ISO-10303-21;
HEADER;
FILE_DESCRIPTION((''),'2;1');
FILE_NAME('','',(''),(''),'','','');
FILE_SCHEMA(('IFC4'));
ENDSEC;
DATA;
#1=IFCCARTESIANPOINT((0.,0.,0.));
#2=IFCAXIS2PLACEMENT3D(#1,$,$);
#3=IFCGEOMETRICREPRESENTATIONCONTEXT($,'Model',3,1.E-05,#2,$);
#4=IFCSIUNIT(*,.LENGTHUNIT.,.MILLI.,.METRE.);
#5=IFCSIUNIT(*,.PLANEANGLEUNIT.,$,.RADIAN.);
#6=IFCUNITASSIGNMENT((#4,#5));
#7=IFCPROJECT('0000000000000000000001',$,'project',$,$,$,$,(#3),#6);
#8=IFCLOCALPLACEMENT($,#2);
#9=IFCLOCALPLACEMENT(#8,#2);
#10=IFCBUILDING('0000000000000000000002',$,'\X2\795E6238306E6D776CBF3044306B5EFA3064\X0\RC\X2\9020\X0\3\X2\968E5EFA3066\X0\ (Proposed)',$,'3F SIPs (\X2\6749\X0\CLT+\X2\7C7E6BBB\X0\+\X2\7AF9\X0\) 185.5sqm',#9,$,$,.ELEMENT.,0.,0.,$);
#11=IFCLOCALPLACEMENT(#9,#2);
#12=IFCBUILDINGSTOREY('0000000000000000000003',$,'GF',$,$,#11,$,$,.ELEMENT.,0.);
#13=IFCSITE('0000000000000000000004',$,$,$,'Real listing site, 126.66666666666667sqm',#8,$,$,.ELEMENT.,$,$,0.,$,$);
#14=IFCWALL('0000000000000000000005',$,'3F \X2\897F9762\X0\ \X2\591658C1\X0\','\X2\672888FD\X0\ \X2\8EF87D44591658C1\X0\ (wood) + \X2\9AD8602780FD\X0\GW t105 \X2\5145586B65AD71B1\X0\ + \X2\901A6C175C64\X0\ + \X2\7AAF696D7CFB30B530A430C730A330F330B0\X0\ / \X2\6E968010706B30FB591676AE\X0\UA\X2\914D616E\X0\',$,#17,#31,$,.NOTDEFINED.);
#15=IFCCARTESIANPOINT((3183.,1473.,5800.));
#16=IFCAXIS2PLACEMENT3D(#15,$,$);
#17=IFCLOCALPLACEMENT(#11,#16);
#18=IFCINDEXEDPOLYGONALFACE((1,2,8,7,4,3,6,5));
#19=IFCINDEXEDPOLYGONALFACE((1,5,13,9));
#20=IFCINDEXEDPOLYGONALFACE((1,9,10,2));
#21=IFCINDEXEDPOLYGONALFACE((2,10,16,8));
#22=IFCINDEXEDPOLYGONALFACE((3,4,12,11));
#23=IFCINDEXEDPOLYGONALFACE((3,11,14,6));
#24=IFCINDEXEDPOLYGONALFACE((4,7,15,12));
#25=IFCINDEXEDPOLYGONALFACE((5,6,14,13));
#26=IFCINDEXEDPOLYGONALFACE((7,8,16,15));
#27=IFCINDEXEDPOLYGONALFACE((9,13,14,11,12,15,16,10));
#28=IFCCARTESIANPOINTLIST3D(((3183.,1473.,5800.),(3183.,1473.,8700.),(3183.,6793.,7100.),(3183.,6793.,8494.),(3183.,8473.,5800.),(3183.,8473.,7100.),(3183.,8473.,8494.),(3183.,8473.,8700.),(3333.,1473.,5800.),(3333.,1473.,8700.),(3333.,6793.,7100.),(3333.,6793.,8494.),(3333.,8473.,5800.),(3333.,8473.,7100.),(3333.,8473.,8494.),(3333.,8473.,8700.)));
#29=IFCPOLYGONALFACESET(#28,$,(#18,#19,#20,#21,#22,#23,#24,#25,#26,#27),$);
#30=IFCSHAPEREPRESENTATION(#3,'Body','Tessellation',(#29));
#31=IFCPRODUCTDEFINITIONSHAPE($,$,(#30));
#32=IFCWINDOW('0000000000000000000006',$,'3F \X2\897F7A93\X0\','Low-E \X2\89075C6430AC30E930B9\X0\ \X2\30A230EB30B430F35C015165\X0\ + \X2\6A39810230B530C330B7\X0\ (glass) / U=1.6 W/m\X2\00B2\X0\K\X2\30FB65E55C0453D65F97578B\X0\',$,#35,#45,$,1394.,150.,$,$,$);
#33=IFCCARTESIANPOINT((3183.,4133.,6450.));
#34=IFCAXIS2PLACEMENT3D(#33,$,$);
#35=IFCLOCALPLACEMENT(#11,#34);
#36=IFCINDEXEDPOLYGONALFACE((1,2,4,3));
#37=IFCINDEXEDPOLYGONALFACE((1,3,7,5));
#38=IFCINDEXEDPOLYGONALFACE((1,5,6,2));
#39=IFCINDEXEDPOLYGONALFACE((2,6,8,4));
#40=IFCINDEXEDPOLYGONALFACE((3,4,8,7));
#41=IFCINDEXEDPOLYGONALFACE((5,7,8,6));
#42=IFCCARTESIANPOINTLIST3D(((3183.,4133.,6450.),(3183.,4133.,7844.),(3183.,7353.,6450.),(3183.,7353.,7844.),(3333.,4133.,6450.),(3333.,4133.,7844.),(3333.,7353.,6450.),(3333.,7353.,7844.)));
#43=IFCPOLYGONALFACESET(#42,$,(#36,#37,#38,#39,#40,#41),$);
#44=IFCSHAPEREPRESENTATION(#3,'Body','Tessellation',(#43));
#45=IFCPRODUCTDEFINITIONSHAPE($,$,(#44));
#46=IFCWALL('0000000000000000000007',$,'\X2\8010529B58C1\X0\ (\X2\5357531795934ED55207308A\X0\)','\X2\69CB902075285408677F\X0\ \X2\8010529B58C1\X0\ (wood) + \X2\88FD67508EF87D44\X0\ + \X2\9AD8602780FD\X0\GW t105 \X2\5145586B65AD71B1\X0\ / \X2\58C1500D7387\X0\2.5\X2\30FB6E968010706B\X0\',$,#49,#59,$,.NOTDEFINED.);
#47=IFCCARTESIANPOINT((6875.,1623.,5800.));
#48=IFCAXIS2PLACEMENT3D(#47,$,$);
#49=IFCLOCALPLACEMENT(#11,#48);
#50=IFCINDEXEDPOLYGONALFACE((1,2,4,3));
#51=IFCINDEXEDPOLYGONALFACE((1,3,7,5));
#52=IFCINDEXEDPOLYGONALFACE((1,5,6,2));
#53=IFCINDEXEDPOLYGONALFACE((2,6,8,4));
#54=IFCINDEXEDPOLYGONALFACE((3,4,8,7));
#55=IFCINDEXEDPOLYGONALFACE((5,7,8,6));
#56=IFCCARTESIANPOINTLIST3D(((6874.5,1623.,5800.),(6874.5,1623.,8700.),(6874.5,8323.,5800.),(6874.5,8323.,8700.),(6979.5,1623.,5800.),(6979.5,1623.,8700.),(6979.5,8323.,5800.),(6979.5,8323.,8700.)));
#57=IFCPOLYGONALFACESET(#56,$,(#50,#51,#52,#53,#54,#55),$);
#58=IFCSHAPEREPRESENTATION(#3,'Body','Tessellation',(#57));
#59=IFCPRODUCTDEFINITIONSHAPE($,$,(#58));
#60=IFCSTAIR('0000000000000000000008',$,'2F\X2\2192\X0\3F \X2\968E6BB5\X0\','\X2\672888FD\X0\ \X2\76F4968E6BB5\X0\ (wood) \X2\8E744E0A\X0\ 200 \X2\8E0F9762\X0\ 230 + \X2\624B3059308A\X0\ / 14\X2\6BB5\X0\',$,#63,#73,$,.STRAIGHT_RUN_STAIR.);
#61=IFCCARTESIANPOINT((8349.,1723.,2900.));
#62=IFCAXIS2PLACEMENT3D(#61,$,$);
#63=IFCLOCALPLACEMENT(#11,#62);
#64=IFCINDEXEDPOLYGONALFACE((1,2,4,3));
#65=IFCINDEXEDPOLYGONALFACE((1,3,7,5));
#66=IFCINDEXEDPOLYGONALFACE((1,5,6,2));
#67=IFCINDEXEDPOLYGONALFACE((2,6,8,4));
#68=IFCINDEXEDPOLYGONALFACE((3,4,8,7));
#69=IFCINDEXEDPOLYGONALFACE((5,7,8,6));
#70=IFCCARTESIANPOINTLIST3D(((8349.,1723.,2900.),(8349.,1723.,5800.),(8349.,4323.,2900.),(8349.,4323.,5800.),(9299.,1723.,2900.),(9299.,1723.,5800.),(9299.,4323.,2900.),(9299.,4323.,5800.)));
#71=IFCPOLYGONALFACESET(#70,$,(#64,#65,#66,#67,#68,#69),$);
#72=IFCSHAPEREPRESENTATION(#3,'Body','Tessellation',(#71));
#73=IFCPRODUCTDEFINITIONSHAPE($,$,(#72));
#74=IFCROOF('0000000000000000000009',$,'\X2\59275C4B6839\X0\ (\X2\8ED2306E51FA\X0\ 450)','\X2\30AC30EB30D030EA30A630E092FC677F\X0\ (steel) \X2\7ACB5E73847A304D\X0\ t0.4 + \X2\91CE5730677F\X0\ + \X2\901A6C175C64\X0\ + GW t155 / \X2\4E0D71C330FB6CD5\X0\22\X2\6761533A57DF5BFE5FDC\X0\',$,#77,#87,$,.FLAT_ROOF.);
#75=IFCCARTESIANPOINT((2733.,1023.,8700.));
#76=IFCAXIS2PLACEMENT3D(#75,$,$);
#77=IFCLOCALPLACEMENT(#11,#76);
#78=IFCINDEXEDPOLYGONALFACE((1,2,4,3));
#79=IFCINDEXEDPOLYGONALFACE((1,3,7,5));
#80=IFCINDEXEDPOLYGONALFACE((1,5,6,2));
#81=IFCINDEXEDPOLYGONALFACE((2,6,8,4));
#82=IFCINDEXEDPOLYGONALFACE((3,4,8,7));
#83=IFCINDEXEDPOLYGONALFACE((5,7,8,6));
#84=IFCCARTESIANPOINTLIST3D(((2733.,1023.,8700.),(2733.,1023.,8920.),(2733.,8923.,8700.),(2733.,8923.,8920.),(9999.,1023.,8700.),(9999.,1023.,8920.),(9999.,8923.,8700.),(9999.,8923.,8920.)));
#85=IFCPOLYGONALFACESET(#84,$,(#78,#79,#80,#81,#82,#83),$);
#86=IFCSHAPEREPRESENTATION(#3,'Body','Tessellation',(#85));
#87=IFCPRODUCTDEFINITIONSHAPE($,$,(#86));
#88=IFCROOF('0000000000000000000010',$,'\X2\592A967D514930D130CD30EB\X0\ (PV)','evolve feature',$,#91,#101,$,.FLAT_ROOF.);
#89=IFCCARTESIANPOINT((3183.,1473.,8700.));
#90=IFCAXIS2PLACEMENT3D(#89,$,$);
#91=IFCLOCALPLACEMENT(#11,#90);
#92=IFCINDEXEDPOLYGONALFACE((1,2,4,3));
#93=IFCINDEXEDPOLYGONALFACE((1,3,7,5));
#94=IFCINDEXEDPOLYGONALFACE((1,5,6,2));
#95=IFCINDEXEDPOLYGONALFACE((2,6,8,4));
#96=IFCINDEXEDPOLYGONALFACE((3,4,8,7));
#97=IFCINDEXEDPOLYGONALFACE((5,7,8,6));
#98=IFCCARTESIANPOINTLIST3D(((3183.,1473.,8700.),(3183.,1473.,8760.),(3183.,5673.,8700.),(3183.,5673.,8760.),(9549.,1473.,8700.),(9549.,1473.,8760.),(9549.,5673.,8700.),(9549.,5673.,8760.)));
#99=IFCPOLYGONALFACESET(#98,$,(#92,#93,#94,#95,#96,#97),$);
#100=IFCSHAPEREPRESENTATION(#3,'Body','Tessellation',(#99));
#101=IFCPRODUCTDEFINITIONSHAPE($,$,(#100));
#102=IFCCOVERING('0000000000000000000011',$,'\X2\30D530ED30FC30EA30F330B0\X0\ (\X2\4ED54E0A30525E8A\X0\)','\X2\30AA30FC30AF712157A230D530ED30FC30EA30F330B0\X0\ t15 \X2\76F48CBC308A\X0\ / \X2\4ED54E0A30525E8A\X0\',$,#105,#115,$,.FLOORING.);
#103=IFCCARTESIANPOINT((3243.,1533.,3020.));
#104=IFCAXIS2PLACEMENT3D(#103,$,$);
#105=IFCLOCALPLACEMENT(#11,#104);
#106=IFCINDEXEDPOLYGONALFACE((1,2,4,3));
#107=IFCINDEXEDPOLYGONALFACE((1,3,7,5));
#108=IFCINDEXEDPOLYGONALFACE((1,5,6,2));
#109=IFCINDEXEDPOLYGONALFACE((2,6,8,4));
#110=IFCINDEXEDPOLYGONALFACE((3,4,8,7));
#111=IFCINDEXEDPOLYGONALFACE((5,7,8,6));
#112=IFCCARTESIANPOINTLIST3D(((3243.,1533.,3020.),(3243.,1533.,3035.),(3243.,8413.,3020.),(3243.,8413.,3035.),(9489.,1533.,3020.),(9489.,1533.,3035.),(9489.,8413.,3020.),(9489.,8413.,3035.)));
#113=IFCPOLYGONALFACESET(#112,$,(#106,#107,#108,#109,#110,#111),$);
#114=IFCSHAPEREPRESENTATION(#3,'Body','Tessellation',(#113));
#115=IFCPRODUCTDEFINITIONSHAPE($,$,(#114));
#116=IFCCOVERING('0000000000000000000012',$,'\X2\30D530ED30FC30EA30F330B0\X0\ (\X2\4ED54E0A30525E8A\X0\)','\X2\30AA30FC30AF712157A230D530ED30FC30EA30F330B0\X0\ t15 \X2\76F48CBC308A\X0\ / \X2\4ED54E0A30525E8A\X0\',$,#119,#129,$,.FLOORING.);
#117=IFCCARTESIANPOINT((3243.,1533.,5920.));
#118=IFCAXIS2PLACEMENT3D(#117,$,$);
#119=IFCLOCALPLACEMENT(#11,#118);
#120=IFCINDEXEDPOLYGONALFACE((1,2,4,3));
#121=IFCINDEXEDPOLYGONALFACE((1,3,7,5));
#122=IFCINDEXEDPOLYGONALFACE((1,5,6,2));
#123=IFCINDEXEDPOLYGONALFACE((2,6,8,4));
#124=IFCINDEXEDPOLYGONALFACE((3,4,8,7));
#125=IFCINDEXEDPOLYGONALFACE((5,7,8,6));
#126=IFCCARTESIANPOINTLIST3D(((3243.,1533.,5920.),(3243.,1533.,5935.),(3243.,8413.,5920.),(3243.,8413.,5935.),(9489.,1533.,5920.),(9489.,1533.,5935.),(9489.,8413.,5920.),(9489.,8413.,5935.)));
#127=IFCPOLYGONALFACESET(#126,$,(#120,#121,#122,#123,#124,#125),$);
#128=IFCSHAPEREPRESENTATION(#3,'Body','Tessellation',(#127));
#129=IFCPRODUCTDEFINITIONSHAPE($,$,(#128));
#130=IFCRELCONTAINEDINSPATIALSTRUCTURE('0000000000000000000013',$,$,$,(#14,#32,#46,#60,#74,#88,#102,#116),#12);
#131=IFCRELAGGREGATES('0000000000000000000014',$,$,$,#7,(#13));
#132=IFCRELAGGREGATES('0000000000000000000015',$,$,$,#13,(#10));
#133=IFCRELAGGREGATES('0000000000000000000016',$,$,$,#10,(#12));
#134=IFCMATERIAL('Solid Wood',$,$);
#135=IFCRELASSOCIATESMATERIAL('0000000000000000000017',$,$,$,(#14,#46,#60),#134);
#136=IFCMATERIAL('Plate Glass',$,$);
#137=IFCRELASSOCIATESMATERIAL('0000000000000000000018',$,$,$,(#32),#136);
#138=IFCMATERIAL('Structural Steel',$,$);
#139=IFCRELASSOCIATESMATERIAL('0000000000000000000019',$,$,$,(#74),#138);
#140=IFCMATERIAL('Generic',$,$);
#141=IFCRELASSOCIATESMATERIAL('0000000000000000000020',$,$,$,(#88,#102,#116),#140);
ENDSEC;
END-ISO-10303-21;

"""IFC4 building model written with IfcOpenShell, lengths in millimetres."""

from ifc_helpers import new_model, si_unit, frame, frame_2d, origin, place, context, project, spatial, rectangle, extrude, material, element, fill, save


model = new_model("IFC4")

# Units and contexts
model_context = context("Model", 3, precision=1e-05, world=origin())
ifc_project = project(units=[si_unit("LENGTHUNIT", "METRE", prefix="MILLI"), si_unit("PLANEANGLEUNIT", "RADIAN")], contexts=[model_context])

# Site, building, storey
site_placement = place(None, origin())
site = spatial("IfcSite", under=ifc_project, at=site_placement, ObjectType="Real listing site, 126.66666666666667sqm", CompositionType="ELEMENT", RefElevation=0.0)
building_placement = place(site_placement, origin())
building = spatial("IfcBuilding", under=site, at=building_placement, Name="神戸の海沿いに建つRC造3階建て (Proposed)", ObjectType="3F SIPs (杉CLT+籾殻+竹) 185.5sqm", CompositionType="ELEMENT", ElevationOfRefHeight=0.0, ElevationOfTerrain=0.0)
storey_placement = place(building_placement, origin())
storey = spatial("IfcBuildingStorey", under=building, at=storey_placement, Name="GF", CompositionType="ELEMENT", Elevation=0.0)

# Shared definitions
ifc_material_1 = material(Name="Solid Wood")

# Shared definitions
ifc_material_2 = material(Name="Plate Glass")

# Shared definitions
ifc_material_3 = material(Name="Generic")

# Wall, opening, window
wall_1_placement = place(storey_placement, frame((3183.0, 1473.0, 5800.0)))
wall_1 = element("IfcWall", 1, at=wall_1_placement, inside=storey, material=ifc_material_1, Name="3F 西面 外壁", Description="木製 軸組外壁 (wood) + 高性能GW t105 充填断熱 + 通気層 + 窯業系サイディング / 準耐火・外皮UA配慮", PredefinedType="NOTDEFINED", context=model_context, shape_type="SweptSolid", body=[
    extrude(rectangle(XDim=150.0, YDim=7000.0, at=frame_2d((75.0, 3500.0))), frame((3183.0, 1473.0, 5800.0)), (0.0, 0.0, 1.0), 2900.0),
])
opening_1_placement = place(storey_placement, frame((3183.0, 4133.0, 6450.0)))
opening_1 = element("IfcOpeningElement", 2, at=opening_1_placement, cuts=wall_1, PredefinedType="NOTDEFINED", context=model_context, shape_type="SweptSolid", body=[
    extrude(rectangle(XDim=150.0, YDim=3220.0, at=frame_2d((75.0, 1610.0))), frame((3183.0, 4133.0, 6450.0)), (0.0, 0.0, 1.0), 1394.0),
])
window_1_placement = place(storey_placement, frame((3183.0, 4133.0, 6450.0)))
window_1 = element("IfcWindow", 3, at=window_1_placement, inside=storey, material=ifc_material_2, Name="3F 西窓", Description="Low-E 複層ガラス アルゴン封入 + 樹脂サッシ (glass) / U=1.6 W/m²K・日射取得型", OverallHeight=1394.0, OverallWidth=150.0, context=model_context, shape_type="SweptSolid", body=[
    extrude(rectangle(XDim=150.0, YDim=3220.0, at=frame_2d((75.0, 1610.0))), frame((3183.0, 4133.0, 6450.0)), (0.0, 0.0, 1.0), 1394.0),
])
fill(opening_1, window_1)

# Wall
wall_2_placement = place(storey_placement, frame((6875.0, 1623.0, 5800.0)))
element("IfcWall", 4, at=wall_2_placement, inside=storey, material=ifc_material_1, Name="耐力壁 (南北間仕切り)", Description="構造用合板 耐力壁 (wood) + 製材軸組 + 高性能GW t105 充填断熱 / 壁倍率2.5・準耐火", PredefinedType="NOTDEFINED", context=model_context, shape_type="SweptSolid", body=[
    extrude(rectangle(XDim=105.0, YDim=6700.0, at=frame_2d((52.0, 3350.0))), frame((6875.0, 1623.0, 5800.0)), (0.0, 0.0, 1.0), 2900.0),
])

# Stair
stair_placement = place(storey_placement, frame((8349.0, 1723.0, 2900.0)))
element("IfcStair", 5, at=stair_placement, inside=storey, material=ifc_material_1, Name="2F→3F 階段", Description="木製 直階段 (wood) 蹴上 200 踏面 230 + 手すり / 14段", PredefinedType="STRAIGHT_RUN_STAIR", context=model_context, shape_type="SweptSolid", body=[
    extrude(rectangle(XDim=950.0, YDim=2600.0, at=frame_2d((475.0, 1300.0))), frame((8349.0, 1723.0, 2900.0)), (0.0, 0.0, 1.0), 2900.0),
])

# Roofs
ifc_material_4 = material(Name="Structural Steel")
roof_1_placement = place(storey_placement, frame((2733.0, 1023.0, 8700.0)))
element("IfcRoof", 6, at=roof_1_placement, inside=storey, material=ifc_material_4, Name="大屋根 (軒の出 450)", Description="ガルバリウム鋼板 (steel) 立平葺き t0.4 + 野地板 + 通気層 + GW t155 / 不燃・法22条区域対応", PredefinedType="FLAT_ROOF", context=model_context, shape_type="SweptSolid", body=[
    extrude(rectangle(XDim=7266.0, YDim=7900.0, at=frame_2d((3633.0, 3950.0))), frame((2733.0, 1023.0, 8700.0)), (0.0, 0.0, 1.0), 220.0),
])
roof_2_placement = place(storey_placement, frame((3183.0, 1473.0, 8700.0)))
element("IfcRoof", 7, at=roof_2_placement, inside=storey, material=ifc_material_3, Name="太陽光パネル (PV)", Description="evolve feature", PredefinedType="FLAT_ROOF", context=model_context, shape_type="SweptSolid", body=[
    extrude(rectangle(XDim=6366.0, YDim=4200.0, at=frame_2d((3183.0, 2100.0))), frame((3183.0, 1473.0, 8700.0)), (0.0, 0.0, 1.0), 60.0),
])

# Coverings
covering_1_placement = place(storey_placement, frame((3243.0, 1533.0, 3020.0)))
element("IfcCovering", 8, at=covering_1_placement, inside=storey, material=ifc_material_3, Name="フローリング (仕上げ床)", Description="オーク無垢フローリング t15 直貼り / 仕上げ床", PredefinedType="FLOORING", context=model_context, shape_type="SweptSolid", body=[
    extrude(rectangle(XDim=6246.0, YDim=6880.0, at=frame_2d((3123.0, 3440.0))), frame((3243.0, 1533.0, 3020.0)), (0.0, 0.0, 1.0), 15.0),
])
covering_2_placement = place(storey_placement, frame((3243.0, 1533.0, 5920.0)))
element("IfcCovering", 9, at=covering_2_placement, inside=storey, material=ifc_material_3, Name="フローリング (仕上げ床)", Description="オーク無垢フローリング t15 直貼り / 仕上げ床", PredefinedType="FLOORING", context=model_context, shape_type="SweptSolid", body=[
    extrude(rectangle(XDim=6246.0, YDim=6880.0, at=frame_2d((3123.0, 3440.0))), frame((3243.0, 1533.0, 5920.0)), (0.0, 0.0, 1.0), 15.0),
])

save(model, "model.ifc")
